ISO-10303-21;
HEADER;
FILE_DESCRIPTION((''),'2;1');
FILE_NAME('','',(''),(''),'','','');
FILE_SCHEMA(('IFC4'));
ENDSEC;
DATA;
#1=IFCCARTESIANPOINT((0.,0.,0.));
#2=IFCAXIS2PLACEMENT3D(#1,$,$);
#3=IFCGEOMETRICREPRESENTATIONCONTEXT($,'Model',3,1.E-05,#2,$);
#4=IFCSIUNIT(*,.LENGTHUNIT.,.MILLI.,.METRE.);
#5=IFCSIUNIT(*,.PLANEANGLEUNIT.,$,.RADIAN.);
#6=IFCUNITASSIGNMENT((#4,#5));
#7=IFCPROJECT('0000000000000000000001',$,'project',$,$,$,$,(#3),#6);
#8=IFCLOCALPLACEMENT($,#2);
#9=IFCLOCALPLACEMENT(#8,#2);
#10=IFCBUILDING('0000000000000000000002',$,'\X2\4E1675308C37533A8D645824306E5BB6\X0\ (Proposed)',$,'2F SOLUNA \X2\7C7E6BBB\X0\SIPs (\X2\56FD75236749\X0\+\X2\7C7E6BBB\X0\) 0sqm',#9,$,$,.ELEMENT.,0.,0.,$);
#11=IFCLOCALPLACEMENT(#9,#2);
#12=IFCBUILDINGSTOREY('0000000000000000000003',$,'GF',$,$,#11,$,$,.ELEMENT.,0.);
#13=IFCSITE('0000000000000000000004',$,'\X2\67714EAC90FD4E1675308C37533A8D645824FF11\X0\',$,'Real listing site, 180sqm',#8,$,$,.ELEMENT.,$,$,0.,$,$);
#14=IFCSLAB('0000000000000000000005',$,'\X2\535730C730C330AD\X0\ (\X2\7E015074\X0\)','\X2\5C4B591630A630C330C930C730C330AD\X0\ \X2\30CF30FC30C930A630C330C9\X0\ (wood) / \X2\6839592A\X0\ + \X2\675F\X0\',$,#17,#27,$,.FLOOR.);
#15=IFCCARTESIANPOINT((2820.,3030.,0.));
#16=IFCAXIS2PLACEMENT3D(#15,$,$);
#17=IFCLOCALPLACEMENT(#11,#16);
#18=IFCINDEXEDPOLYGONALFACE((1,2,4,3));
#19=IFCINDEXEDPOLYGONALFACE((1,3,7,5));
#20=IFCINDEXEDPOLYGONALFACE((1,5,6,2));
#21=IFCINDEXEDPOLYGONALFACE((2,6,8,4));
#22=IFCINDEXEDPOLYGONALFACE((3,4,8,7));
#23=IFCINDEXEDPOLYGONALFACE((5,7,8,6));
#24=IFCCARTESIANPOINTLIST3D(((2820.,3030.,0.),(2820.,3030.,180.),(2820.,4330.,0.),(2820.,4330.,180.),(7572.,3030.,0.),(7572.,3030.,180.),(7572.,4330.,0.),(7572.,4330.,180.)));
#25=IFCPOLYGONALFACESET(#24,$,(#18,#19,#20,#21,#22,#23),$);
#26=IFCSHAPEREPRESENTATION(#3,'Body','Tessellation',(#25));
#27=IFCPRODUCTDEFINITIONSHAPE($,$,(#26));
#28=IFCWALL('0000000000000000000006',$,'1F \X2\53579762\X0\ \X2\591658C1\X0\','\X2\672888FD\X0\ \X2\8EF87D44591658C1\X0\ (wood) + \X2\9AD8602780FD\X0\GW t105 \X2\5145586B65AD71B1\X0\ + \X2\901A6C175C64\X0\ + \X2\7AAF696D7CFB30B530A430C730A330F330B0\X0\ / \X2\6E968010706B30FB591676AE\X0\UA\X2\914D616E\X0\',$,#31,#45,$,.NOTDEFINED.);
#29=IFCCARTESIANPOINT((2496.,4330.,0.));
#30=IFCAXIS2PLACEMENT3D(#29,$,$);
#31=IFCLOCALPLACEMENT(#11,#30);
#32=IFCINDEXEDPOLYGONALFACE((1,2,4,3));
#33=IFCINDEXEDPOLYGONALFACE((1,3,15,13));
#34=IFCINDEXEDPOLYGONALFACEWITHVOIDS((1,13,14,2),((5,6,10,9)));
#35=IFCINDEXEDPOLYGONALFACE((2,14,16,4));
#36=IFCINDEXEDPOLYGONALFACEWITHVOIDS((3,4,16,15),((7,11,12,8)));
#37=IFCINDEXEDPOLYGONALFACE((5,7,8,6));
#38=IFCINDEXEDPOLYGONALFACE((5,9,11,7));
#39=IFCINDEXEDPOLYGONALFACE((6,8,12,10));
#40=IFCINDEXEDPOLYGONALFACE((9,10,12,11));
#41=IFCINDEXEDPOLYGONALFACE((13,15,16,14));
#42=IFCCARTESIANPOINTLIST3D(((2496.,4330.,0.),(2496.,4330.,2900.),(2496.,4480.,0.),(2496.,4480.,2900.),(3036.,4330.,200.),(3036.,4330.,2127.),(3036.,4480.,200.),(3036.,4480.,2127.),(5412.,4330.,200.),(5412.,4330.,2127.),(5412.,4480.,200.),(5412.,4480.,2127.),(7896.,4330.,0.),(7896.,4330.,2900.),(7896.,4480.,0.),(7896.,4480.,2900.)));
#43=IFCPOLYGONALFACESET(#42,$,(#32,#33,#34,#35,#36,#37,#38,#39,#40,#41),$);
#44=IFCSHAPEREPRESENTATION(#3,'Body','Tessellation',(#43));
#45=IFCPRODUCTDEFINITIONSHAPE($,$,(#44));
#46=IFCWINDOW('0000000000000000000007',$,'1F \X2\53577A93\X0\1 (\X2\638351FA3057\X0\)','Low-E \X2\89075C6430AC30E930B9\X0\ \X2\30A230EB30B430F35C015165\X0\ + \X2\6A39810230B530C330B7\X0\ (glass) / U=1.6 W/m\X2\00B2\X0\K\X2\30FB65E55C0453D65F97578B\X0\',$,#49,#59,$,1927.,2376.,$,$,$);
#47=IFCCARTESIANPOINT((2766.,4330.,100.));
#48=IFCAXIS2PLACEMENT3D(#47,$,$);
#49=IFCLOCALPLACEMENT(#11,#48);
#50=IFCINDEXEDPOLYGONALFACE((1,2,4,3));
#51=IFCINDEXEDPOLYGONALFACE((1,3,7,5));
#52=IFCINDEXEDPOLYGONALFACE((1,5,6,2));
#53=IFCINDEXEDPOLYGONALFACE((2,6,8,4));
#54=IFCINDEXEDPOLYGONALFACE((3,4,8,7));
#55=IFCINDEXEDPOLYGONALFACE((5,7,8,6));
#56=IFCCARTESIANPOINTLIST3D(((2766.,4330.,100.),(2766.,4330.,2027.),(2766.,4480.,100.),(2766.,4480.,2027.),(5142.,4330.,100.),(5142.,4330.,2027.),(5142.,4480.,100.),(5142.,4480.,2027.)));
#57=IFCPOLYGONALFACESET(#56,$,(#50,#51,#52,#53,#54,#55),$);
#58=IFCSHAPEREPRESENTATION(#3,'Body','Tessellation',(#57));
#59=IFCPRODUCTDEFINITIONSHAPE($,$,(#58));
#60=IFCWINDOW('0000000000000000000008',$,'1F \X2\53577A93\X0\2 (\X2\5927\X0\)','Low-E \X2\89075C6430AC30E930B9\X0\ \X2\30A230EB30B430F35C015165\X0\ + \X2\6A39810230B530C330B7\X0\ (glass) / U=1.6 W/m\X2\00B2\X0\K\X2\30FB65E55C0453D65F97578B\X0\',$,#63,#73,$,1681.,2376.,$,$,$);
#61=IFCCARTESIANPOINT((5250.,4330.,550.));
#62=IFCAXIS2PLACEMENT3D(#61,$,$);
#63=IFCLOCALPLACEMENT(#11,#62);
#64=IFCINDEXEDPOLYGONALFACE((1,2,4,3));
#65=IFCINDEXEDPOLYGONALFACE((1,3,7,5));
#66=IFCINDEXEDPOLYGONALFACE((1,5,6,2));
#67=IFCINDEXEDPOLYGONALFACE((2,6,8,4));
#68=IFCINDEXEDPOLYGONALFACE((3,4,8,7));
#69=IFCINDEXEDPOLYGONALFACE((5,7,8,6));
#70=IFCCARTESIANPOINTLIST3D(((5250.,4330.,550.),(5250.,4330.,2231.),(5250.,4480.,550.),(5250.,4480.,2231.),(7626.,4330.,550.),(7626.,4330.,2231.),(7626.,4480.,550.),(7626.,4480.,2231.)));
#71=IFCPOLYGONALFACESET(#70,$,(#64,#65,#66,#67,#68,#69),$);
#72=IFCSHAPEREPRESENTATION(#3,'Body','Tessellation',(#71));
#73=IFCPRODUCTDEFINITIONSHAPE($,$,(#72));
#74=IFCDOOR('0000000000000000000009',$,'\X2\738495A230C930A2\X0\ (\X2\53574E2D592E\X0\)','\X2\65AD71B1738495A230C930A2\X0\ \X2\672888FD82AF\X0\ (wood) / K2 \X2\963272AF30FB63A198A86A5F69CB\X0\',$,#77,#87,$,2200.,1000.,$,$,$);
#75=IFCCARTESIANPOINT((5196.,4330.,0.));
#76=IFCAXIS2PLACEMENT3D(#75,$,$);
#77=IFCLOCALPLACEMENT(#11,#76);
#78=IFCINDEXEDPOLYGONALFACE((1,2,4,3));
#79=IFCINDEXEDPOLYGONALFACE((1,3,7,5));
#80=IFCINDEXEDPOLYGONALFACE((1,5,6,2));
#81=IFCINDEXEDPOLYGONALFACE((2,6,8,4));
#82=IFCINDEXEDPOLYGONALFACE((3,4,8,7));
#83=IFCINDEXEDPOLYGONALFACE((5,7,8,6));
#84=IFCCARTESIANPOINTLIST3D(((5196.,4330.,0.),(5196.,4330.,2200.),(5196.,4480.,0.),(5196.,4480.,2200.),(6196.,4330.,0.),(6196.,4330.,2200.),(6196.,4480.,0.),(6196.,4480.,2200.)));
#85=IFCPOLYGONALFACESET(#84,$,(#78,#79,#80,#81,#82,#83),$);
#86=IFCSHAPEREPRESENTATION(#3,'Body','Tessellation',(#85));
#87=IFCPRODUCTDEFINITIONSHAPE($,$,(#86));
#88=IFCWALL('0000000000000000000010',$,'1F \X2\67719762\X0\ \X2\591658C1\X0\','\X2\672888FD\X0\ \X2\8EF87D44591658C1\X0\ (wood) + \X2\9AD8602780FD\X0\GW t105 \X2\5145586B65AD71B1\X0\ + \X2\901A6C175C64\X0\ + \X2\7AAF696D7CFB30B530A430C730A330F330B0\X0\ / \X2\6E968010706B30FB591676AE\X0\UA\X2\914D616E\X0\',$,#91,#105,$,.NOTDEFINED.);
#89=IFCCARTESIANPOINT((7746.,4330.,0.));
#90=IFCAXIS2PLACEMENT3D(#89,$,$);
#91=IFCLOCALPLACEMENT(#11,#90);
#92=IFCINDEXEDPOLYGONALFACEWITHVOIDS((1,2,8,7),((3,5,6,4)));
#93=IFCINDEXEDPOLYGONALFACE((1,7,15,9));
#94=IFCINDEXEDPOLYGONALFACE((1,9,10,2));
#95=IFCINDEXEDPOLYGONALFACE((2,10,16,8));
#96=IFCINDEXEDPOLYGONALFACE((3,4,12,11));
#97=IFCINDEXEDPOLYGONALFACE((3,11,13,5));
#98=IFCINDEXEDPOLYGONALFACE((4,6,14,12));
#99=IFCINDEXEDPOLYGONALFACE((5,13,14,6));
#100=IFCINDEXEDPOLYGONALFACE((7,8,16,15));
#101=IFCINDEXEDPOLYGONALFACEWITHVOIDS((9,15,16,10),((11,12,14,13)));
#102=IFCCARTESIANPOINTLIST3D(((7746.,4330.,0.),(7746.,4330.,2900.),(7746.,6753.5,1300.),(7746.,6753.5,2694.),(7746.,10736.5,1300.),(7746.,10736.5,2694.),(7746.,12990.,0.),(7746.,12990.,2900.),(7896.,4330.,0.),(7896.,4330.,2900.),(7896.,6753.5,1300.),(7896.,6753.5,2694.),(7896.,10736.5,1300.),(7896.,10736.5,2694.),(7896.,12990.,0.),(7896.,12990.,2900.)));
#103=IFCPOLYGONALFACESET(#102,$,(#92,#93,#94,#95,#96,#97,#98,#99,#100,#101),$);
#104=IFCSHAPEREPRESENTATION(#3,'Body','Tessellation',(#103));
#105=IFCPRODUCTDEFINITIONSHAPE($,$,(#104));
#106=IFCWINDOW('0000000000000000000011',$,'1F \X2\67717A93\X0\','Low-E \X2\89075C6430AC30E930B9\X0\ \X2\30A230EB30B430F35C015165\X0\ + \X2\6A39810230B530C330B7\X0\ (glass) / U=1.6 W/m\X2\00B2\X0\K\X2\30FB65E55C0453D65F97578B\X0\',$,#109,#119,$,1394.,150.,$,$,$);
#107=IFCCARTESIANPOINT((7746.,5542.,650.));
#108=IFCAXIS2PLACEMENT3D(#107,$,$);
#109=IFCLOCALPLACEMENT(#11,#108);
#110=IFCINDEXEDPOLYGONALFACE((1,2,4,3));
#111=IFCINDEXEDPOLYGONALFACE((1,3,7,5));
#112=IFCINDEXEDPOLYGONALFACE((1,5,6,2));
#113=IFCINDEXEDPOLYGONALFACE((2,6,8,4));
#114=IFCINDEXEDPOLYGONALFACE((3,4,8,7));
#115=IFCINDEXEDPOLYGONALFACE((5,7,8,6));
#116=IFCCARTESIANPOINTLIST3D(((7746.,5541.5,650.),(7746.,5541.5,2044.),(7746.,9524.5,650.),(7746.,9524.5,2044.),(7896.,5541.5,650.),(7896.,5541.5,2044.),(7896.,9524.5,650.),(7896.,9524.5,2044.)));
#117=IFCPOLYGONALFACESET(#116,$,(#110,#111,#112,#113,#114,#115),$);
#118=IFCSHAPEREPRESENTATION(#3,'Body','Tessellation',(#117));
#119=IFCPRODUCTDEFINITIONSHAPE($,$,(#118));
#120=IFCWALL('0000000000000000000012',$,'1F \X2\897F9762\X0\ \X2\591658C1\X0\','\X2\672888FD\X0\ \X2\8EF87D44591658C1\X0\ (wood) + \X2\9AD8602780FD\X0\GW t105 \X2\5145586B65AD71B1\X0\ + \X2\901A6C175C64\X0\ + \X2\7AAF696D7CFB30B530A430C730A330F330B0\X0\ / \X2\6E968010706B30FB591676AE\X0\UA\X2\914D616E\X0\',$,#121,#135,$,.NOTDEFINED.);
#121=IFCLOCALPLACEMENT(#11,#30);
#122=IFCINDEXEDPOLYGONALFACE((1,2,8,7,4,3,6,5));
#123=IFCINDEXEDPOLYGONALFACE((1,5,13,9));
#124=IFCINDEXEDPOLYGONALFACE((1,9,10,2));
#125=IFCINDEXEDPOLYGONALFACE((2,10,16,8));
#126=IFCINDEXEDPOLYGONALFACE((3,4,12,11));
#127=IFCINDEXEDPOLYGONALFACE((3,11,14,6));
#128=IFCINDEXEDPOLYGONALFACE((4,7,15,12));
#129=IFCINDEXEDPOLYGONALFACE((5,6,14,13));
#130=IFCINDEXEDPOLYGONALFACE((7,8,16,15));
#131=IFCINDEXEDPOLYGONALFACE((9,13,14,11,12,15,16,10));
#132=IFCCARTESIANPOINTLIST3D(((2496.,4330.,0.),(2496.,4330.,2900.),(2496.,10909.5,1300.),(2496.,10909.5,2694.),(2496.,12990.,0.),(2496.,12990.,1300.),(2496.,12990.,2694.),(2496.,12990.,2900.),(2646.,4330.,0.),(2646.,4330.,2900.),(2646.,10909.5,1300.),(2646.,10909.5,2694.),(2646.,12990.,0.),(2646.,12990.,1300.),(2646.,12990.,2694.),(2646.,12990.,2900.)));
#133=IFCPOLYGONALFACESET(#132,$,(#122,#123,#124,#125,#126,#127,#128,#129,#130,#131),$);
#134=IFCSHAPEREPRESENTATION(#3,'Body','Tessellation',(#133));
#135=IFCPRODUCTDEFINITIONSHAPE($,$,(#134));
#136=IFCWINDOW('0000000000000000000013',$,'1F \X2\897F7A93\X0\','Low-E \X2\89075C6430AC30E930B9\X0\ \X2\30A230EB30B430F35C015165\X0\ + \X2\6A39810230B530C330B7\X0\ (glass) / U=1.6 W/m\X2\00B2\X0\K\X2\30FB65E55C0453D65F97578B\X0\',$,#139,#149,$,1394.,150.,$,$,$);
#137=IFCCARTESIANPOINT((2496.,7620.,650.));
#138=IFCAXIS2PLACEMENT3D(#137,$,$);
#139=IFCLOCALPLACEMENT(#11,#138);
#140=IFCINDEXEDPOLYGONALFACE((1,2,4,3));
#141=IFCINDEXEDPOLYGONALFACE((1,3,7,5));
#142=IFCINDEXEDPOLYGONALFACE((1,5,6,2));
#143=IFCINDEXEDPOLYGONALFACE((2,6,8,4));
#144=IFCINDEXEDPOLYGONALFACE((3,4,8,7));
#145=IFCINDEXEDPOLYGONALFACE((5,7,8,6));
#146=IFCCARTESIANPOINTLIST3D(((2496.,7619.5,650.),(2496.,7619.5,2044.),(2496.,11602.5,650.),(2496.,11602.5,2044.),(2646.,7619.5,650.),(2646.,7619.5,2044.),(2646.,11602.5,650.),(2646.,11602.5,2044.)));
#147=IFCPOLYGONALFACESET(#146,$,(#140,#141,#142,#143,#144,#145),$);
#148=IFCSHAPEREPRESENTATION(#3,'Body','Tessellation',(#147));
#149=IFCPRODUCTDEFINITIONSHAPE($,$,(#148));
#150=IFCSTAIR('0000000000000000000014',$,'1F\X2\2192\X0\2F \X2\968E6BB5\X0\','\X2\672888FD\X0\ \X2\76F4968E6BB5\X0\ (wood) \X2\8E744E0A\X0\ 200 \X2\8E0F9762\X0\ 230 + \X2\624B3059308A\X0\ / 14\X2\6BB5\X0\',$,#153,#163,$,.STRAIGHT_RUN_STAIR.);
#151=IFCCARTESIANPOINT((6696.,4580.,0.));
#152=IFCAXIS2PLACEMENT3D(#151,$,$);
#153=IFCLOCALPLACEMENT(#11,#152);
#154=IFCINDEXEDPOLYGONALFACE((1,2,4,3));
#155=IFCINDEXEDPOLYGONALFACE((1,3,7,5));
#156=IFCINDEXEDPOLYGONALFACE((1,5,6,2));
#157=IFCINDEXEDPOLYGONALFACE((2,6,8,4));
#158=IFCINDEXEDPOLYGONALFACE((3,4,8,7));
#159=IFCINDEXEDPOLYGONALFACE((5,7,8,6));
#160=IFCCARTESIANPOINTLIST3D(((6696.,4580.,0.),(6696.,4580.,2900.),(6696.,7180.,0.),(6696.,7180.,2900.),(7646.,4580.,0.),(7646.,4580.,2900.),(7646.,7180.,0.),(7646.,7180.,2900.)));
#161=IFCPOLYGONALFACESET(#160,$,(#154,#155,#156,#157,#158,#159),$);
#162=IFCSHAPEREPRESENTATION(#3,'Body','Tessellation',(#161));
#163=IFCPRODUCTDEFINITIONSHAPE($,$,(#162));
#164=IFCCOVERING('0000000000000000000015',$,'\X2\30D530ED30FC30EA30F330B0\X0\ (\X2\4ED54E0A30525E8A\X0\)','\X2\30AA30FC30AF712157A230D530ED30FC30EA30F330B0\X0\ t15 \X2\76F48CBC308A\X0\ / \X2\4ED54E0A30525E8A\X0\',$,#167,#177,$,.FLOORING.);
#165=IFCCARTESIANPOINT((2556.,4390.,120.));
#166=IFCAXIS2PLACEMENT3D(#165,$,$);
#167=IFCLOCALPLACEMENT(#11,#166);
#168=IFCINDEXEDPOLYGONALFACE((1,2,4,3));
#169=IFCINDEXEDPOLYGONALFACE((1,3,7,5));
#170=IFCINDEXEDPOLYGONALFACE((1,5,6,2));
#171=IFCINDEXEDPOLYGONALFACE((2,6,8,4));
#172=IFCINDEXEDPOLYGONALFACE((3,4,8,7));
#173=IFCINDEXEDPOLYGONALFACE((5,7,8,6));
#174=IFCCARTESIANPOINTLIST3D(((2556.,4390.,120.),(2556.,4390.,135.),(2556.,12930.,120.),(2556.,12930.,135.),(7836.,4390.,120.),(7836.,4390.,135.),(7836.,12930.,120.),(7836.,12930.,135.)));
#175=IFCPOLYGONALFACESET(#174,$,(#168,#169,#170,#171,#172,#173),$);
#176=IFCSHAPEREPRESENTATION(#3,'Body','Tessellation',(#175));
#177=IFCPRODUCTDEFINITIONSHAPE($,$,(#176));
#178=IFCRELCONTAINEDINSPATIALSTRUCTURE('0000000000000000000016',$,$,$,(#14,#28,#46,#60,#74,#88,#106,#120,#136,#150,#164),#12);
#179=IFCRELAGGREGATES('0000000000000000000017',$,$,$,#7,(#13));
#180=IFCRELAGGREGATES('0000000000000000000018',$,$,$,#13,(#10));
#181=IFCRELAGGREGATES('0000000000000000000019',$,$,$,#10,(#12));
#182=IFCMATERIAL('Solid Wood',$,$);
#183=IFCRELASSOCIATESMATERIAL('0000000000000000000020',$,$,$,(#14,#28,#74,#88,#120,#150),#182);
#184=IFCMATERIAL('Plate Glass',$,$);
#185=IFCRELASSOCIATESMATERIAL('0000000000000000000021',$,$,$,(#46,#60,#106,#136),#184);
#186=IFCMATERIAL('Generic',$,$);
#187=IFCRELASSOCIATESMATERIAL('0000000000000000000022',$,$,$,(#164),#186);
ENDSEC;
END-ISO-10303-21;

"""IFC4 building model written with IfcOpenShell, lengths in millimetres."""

from ifc_helpers import new_model, si_unit, frame, frame_2d, origin, place, context, project, spatial, rectangle, extrude, material, element, fill, save


model = new_model("IFC4")

# Units and contexts
model_context = context("Model", 3, precision=1e-05, world=origin())
ifc_project = project(units=[si_unit("LENGTHUNIT", "METRE", prefix="MILLI"), si_unit("PLANEANGLEUNIT", "RADIAN")], contexts=[model_context])

# Site, building, storey
site_placement = place(None, origin())
site = spatial("IfcSite", under=ifc_project, at=site_placement, Name="東京都世田谷区赤堤１", ObjectType="Real listing site, 180sqm", CompositionType="ELEMENT", RefElevation=0.0)
building_placement = place(site_placement, origin())
building = spatial("IfcBuilding", under=site, at=building_placement, Name="世田谷区赤堤の家 (Proposed)", ObjectType="2F SOLUNA 籾殻SIPs (国産杉+籾殻) 0sqm", CompositionType="ELEMENT", ElevationOfRefHeight=0.0, ElevationOfTerrain=0.0)
storey_placement = place(building_placement, origin())
storey = spatial("IfcBuildingStorey", under=building, at=storey_placement, Name="GF", CompositionType="ELEMENT", Elevation=0.0)

# Slab
ifc_material_1 = material(Name="Solid Wood")
slab_1_placement = place(storey_placement, frame((2820.0, 3030.0, 0.0)))
element("IfcSlab", 1, at=slab_1_placement, inside=storey, material=ifc_material_1, Name="南デッキ (縁側)", Description="屋外ウッドデッキ ハードウッド (wood) / 根太 + 束", PredefinedType="FLOOR", context=model_context, shape_type="SweptSolid", body=[
    extrude(rectangle(XDim=4752.0, YDim=1300.0, at=frame_2d((2376.0, 650.0))), frame((2820.0, 3030.0, 0.0)), (0.0, 0.0, 1.0), 180.0),
])

# Wall, openings, windows, door
wall_1_placement = place(storey_placement, frame((2496.0, 4330.0, 0.0)))
wall_1 = element("IfcWall", 2, at=wall_1_placement, inside=storey, material=ifc_material_1, Name="1F 南面 外壁", Description="木製 軸組外壁 (wood) + 高性能GW t105 充填断熱 + 通気層 + 窯業系サイディング / 準耐火・外皮UA配慮", PredefinedType="NOTDEFINED", context=model_context, shape_type="SweptSolid", body=[
    extrude(rectangle(XDim=5400.0, YDim=150.0, at=frame_2d((2700.0, 75.0))), frame((2496.0, 4330.0, 0.0)), (0.0, 0.0, 1.0), 2900.0),
])
opening_1_placement = place(storey_placement, frame((2766.0, 4330.0, 100.0)))
opening_1 = element("IfcOpeningElement", 3, at=opening_1_placement, cuts=wall_1, PredefinedType="NOTDEFINED", context=model_context, shape_type="SweptSolid", body=[
    extrude(rectangle(XDim=2376.0, YDim=150.0, at=frame_2d((1188.0, 75.0))), frame((2766.0, 4330.0, 100.0)), (0.0, 0.0, 1.0), 1927.0),
])
opening_2_placement = place(storey_placement, frame((5250.0, 4330.0, 550.0)))
opening_2 = element("IfcOpeningElement", 4, at=opening_2_placement, cuts=wall_1, PredefinedType="NOTDEFINED", context=model_context, shape_type="SweptSolid", body=[
    extrude(rectangle(XDim=2376.0, YDim=150.0, at=frame_2d((1188.0, 75.0))), frame((5250.0, 4330.0, 550.0)), (0.0, 0.0, 1.0), 1681.0),
])
opening_3_placement = place(storey_placement, frame((5196.0, 4330.0, 0.0)))
opening_3 = element("IfcOpeningElement", 5, at=opening_3_placement, cuts=wall_1, PredefinedType="NOTDEFINED", context=model_context, shape_type="SweptSolid", body=[
    extrude(rectangle(XDim=1000.0, YDim=150.0, at=frame_2d((500.0, 75.0))), frame((5196.0, 4330.0, 0.0)), (0.0, 0.0, 1.0), 2200.0),
])
ifc_material_2 = material(Name="Plate Glass")
window_1_placement = place(storey_placement, frame((2766.0, 4330.0, 100.0)))
window_1 = element("IfcWindow", 6, at=window_1_placement, inside=storey, material=ifc_material_2, Name="1F 南窓1 (掃出し)", Description="Low-E 複層ガラス アルゴン封入 + 樹脂サッシ (glass) / U=1.6 W/m²K・日射取得型", OverallHeight=1927.0, OverallWidth=2376.0, context=model_context, shape_type="SweptSolid", body=[
    extrude(rectangle(XDim=2376.0, YDim=150.0, at=frame_2d((1188.0, 75.0))), frame((2766.0, 4330.0, 100.0)), (0.0, 0.0, 1.0), 1927.0),
])
fill(opening_1, window_1)
window_2_placement = place(storey_placement, frame((5250.0, 4330.0, 550.0)))
window_2 = element("IfcWindow", 7, at=window_2_placement, inside=storey, material=ifc_material_2, Name="1F 南窓2 (大)", Description="Low-E 複層ガラス アルゴン封入 + 樹脂サッシ (glass) / U=1.6 W/m²K・日射取得型", OverallHeight=1681.0, OverallWidth=2376.0, context=model_context, shape_type="SweptSolid", body=[
    extrude(rectangle(XDim=2376.0, YDim=150.0, at=frame_2d((1188.0, 75.0))), frame((5250.0, 4330.0, 550.0)), (0.0, 0.0, 1.0), 1681.0),
])
fill(opening_2, window_2)
door_placement = place(storey_placement, frame((5196.0, 4330.0, 0.0)))
door = element("IfcDoor", 8, at=door_placement, inside=storey, material=ifc_material_1, Name="玄関ドア (南中央)", Description="断熱玄関ドア 木製芯 (wood) / K2 防犯・採風機構", OverallHeight=2200.0, OverallWidth=1000.0, context=model_context, shape_type="SweptSolid", body=[
    extrude(rectangle(XDim=1000.0, YDim=150.0, at=frame_2d((500.0, 75.0))), frame((5196.0, 4330.0, 0.0)), (0.0, 0.0, 1.0), 2200.0),
])
fill(opening_3, door)

# Walls, openings, windows
wall_2_placement = place(storey_placement, frame((7746.0, 4330.0, 0.0)))
wall_2 = element("IfcWall", 9, at=wall_2_placement, inside=storey, material=ifc_material_1, Name="1F 東面 外壁", Description="木製 軸組外壁 (wood) + 高性能GW t105 充填断熱 + 通気層 + 窯業系サイディング / 準耐火・外皮UA配慮", PredefinedType="NOTDEFINED", context=model_context, shape_type="SweptSolid", body=[
    extrude(rectangle(XDim=150.0, YDim=8660.0, at=frame_2d((75.0, 4330.0))), frame((7746.0, 4330.0, 0.0)), (0.0, 0.0, 1.0), 2900.0),
])
opening_4_placement = place(storey_placement, frame((7746.0, 5542.0, 650.0)))
opening_4 = element("IfcOpeningElement", 10, at=opening_4_placement, cuts=wall_2, PredefinedType="NOTDEFINED", context=model_context, shape_type="SweptSolid", body=[
    extrude(rectangle(XDim=150.0, YDim=3983.0, at=frame_2d((75.0, 1991.0))), frame((7746.0, 5542.0, 650.0)), (0.0, 0.0, 1.0), 1394.0),
])
window_3_placement = place(storey_placement, frame((7746.0, 5542.0, 650.0)))
window_3 = element("IfcWindow", 11, at=window_3_placement, inside=storey, material=ifc_material_2, Name="1F 東窓", Description="Low-E 複層ガラス アルゴン封入 + 樹脂サッシ (glass) / U=1.6 W/m²K・日射取得型", OverallHeight=1394.0, OverallWidth=150.0, context=model_context, shape_type="SweptSolid", body=[
    extrude(rectangle(XDim=150.0, YDim=3983.0, at=frame_2d((75.0, 1991.0))), frame((7746.0, 5542.0, 650.0)), (0.0, 0.0, 1.0), 1394.0),
])
fill(opening_4, window_3)
wall_3_placement = place(storey_placement, frame((2496.0, 4330.0, 0.0)))
wall_3 = element("IfcWall", 12, at=wall_3_placement, inside=storey, material=ifc_material_1, Name="1F 西面 外壁", Description="木製 軸組外壁 (wood) + 高性能GW t105 充填断熱 + 通気層 + 窯業系サイディング / 準耐火・外皮UA配慮", PredefinedType="NOTDEFINED", context=model_context, shape_type="SweptSolid", body=[
    extrude(rectangle(XDim=150.0, YDim=8660.0, at=frame_2d((75.0, 4330.0))), frame((2496.0, 4330.0, 0.0)), (0.0, 0.0, 1.0), 2900.0),
])
opening_5_placement = place(storey_placement, frame((2496.0, 7620.0, 650.0)))
opening_5 = element("IfcOpeningElement", 13, at=opening_5_placement, cuts=wall_3, PredefinedType="NOTDEFINED", context=model_context, shape_type="SweptSolid", body=[
    extrude(rectangle(XDim=150.0, YDim=3983.0, at=frame_2d((75.0, 1991.0))), frame((2496.0, 7620.0, 650.0)), (0.0, 0.0, 1.0), 1394.0),
])
window_4_placement = place(storey_placement, frame((2496.0, 7620.0, 650.0)))
window_4 = element("IfcWindow", 14, at=window_4_placement, inside=storey, material=ifc_material_2, Name="1F 西窓", Description="Low-E 複層ガラス アルゴン封入 + 樹脂サッシ (glass) / U=1.6 W/m²K・日射取得型", OverallHeight=1394.0, OverallWidth=150.0, context=model_context, shape_type="SweptSolid", body=[
    extrude(rectangle(XDim=150.0, YDim=3983.0, at=frame_2d((75.0, 1991.0))), frame((2496.0, 7620.0, 650.0)), (0.0, 0.0, 1.0), 1394.0),
])
fill(opening_5, window_4)

# Stair
stair_placement = place(storey_placement, frame((6696.0, 4580.0, 0.0)))
element("IfcStair", 15, at=stair_placement, inside=storey, material=ifc_material_1, Name="1F→2F 階段", Description="木製 直階段 (wood) 蹴上 200 踏面 230 + 手すり / 14段", PredefinedType="STRAIGHT_RUN_STAIR", context=model_context, shape_type="SweptSolid", body=[
    extrude(rectangle(XDim=950.0, YDim=2600.0, at=frame_2d((475.0, 1300.0))), frame((6696.0, 4580.0, 0.0)), (0.0, 0.0, 1.0), 2900.0),
])

# Covering
ifc_material_3 = material(Name="Generic")
covering_placement = place(storey_placement, frame((2556.0, 4390.0, 120.0)))
element("IfcCovering", 16, at=covering_placement, inside=storey, material=ifc_material_3, Name="フローリング (仕上げ床)", Description="オーク無垢フローリング t15 直貼り / 仕上げ床", PredefinedType="FLOORING", context=model_context, shape_type="SweptSolid", body=[
    extrude(rectangle(XDim=5280.0, YDim=8540.0, at=frame_2d((2640.0, 4270.0))), frame((2556.0, 4390.0, 120.0)), (0.0, 0.0, 1.0), 15.0),
])

save(model, "model.ifc")
